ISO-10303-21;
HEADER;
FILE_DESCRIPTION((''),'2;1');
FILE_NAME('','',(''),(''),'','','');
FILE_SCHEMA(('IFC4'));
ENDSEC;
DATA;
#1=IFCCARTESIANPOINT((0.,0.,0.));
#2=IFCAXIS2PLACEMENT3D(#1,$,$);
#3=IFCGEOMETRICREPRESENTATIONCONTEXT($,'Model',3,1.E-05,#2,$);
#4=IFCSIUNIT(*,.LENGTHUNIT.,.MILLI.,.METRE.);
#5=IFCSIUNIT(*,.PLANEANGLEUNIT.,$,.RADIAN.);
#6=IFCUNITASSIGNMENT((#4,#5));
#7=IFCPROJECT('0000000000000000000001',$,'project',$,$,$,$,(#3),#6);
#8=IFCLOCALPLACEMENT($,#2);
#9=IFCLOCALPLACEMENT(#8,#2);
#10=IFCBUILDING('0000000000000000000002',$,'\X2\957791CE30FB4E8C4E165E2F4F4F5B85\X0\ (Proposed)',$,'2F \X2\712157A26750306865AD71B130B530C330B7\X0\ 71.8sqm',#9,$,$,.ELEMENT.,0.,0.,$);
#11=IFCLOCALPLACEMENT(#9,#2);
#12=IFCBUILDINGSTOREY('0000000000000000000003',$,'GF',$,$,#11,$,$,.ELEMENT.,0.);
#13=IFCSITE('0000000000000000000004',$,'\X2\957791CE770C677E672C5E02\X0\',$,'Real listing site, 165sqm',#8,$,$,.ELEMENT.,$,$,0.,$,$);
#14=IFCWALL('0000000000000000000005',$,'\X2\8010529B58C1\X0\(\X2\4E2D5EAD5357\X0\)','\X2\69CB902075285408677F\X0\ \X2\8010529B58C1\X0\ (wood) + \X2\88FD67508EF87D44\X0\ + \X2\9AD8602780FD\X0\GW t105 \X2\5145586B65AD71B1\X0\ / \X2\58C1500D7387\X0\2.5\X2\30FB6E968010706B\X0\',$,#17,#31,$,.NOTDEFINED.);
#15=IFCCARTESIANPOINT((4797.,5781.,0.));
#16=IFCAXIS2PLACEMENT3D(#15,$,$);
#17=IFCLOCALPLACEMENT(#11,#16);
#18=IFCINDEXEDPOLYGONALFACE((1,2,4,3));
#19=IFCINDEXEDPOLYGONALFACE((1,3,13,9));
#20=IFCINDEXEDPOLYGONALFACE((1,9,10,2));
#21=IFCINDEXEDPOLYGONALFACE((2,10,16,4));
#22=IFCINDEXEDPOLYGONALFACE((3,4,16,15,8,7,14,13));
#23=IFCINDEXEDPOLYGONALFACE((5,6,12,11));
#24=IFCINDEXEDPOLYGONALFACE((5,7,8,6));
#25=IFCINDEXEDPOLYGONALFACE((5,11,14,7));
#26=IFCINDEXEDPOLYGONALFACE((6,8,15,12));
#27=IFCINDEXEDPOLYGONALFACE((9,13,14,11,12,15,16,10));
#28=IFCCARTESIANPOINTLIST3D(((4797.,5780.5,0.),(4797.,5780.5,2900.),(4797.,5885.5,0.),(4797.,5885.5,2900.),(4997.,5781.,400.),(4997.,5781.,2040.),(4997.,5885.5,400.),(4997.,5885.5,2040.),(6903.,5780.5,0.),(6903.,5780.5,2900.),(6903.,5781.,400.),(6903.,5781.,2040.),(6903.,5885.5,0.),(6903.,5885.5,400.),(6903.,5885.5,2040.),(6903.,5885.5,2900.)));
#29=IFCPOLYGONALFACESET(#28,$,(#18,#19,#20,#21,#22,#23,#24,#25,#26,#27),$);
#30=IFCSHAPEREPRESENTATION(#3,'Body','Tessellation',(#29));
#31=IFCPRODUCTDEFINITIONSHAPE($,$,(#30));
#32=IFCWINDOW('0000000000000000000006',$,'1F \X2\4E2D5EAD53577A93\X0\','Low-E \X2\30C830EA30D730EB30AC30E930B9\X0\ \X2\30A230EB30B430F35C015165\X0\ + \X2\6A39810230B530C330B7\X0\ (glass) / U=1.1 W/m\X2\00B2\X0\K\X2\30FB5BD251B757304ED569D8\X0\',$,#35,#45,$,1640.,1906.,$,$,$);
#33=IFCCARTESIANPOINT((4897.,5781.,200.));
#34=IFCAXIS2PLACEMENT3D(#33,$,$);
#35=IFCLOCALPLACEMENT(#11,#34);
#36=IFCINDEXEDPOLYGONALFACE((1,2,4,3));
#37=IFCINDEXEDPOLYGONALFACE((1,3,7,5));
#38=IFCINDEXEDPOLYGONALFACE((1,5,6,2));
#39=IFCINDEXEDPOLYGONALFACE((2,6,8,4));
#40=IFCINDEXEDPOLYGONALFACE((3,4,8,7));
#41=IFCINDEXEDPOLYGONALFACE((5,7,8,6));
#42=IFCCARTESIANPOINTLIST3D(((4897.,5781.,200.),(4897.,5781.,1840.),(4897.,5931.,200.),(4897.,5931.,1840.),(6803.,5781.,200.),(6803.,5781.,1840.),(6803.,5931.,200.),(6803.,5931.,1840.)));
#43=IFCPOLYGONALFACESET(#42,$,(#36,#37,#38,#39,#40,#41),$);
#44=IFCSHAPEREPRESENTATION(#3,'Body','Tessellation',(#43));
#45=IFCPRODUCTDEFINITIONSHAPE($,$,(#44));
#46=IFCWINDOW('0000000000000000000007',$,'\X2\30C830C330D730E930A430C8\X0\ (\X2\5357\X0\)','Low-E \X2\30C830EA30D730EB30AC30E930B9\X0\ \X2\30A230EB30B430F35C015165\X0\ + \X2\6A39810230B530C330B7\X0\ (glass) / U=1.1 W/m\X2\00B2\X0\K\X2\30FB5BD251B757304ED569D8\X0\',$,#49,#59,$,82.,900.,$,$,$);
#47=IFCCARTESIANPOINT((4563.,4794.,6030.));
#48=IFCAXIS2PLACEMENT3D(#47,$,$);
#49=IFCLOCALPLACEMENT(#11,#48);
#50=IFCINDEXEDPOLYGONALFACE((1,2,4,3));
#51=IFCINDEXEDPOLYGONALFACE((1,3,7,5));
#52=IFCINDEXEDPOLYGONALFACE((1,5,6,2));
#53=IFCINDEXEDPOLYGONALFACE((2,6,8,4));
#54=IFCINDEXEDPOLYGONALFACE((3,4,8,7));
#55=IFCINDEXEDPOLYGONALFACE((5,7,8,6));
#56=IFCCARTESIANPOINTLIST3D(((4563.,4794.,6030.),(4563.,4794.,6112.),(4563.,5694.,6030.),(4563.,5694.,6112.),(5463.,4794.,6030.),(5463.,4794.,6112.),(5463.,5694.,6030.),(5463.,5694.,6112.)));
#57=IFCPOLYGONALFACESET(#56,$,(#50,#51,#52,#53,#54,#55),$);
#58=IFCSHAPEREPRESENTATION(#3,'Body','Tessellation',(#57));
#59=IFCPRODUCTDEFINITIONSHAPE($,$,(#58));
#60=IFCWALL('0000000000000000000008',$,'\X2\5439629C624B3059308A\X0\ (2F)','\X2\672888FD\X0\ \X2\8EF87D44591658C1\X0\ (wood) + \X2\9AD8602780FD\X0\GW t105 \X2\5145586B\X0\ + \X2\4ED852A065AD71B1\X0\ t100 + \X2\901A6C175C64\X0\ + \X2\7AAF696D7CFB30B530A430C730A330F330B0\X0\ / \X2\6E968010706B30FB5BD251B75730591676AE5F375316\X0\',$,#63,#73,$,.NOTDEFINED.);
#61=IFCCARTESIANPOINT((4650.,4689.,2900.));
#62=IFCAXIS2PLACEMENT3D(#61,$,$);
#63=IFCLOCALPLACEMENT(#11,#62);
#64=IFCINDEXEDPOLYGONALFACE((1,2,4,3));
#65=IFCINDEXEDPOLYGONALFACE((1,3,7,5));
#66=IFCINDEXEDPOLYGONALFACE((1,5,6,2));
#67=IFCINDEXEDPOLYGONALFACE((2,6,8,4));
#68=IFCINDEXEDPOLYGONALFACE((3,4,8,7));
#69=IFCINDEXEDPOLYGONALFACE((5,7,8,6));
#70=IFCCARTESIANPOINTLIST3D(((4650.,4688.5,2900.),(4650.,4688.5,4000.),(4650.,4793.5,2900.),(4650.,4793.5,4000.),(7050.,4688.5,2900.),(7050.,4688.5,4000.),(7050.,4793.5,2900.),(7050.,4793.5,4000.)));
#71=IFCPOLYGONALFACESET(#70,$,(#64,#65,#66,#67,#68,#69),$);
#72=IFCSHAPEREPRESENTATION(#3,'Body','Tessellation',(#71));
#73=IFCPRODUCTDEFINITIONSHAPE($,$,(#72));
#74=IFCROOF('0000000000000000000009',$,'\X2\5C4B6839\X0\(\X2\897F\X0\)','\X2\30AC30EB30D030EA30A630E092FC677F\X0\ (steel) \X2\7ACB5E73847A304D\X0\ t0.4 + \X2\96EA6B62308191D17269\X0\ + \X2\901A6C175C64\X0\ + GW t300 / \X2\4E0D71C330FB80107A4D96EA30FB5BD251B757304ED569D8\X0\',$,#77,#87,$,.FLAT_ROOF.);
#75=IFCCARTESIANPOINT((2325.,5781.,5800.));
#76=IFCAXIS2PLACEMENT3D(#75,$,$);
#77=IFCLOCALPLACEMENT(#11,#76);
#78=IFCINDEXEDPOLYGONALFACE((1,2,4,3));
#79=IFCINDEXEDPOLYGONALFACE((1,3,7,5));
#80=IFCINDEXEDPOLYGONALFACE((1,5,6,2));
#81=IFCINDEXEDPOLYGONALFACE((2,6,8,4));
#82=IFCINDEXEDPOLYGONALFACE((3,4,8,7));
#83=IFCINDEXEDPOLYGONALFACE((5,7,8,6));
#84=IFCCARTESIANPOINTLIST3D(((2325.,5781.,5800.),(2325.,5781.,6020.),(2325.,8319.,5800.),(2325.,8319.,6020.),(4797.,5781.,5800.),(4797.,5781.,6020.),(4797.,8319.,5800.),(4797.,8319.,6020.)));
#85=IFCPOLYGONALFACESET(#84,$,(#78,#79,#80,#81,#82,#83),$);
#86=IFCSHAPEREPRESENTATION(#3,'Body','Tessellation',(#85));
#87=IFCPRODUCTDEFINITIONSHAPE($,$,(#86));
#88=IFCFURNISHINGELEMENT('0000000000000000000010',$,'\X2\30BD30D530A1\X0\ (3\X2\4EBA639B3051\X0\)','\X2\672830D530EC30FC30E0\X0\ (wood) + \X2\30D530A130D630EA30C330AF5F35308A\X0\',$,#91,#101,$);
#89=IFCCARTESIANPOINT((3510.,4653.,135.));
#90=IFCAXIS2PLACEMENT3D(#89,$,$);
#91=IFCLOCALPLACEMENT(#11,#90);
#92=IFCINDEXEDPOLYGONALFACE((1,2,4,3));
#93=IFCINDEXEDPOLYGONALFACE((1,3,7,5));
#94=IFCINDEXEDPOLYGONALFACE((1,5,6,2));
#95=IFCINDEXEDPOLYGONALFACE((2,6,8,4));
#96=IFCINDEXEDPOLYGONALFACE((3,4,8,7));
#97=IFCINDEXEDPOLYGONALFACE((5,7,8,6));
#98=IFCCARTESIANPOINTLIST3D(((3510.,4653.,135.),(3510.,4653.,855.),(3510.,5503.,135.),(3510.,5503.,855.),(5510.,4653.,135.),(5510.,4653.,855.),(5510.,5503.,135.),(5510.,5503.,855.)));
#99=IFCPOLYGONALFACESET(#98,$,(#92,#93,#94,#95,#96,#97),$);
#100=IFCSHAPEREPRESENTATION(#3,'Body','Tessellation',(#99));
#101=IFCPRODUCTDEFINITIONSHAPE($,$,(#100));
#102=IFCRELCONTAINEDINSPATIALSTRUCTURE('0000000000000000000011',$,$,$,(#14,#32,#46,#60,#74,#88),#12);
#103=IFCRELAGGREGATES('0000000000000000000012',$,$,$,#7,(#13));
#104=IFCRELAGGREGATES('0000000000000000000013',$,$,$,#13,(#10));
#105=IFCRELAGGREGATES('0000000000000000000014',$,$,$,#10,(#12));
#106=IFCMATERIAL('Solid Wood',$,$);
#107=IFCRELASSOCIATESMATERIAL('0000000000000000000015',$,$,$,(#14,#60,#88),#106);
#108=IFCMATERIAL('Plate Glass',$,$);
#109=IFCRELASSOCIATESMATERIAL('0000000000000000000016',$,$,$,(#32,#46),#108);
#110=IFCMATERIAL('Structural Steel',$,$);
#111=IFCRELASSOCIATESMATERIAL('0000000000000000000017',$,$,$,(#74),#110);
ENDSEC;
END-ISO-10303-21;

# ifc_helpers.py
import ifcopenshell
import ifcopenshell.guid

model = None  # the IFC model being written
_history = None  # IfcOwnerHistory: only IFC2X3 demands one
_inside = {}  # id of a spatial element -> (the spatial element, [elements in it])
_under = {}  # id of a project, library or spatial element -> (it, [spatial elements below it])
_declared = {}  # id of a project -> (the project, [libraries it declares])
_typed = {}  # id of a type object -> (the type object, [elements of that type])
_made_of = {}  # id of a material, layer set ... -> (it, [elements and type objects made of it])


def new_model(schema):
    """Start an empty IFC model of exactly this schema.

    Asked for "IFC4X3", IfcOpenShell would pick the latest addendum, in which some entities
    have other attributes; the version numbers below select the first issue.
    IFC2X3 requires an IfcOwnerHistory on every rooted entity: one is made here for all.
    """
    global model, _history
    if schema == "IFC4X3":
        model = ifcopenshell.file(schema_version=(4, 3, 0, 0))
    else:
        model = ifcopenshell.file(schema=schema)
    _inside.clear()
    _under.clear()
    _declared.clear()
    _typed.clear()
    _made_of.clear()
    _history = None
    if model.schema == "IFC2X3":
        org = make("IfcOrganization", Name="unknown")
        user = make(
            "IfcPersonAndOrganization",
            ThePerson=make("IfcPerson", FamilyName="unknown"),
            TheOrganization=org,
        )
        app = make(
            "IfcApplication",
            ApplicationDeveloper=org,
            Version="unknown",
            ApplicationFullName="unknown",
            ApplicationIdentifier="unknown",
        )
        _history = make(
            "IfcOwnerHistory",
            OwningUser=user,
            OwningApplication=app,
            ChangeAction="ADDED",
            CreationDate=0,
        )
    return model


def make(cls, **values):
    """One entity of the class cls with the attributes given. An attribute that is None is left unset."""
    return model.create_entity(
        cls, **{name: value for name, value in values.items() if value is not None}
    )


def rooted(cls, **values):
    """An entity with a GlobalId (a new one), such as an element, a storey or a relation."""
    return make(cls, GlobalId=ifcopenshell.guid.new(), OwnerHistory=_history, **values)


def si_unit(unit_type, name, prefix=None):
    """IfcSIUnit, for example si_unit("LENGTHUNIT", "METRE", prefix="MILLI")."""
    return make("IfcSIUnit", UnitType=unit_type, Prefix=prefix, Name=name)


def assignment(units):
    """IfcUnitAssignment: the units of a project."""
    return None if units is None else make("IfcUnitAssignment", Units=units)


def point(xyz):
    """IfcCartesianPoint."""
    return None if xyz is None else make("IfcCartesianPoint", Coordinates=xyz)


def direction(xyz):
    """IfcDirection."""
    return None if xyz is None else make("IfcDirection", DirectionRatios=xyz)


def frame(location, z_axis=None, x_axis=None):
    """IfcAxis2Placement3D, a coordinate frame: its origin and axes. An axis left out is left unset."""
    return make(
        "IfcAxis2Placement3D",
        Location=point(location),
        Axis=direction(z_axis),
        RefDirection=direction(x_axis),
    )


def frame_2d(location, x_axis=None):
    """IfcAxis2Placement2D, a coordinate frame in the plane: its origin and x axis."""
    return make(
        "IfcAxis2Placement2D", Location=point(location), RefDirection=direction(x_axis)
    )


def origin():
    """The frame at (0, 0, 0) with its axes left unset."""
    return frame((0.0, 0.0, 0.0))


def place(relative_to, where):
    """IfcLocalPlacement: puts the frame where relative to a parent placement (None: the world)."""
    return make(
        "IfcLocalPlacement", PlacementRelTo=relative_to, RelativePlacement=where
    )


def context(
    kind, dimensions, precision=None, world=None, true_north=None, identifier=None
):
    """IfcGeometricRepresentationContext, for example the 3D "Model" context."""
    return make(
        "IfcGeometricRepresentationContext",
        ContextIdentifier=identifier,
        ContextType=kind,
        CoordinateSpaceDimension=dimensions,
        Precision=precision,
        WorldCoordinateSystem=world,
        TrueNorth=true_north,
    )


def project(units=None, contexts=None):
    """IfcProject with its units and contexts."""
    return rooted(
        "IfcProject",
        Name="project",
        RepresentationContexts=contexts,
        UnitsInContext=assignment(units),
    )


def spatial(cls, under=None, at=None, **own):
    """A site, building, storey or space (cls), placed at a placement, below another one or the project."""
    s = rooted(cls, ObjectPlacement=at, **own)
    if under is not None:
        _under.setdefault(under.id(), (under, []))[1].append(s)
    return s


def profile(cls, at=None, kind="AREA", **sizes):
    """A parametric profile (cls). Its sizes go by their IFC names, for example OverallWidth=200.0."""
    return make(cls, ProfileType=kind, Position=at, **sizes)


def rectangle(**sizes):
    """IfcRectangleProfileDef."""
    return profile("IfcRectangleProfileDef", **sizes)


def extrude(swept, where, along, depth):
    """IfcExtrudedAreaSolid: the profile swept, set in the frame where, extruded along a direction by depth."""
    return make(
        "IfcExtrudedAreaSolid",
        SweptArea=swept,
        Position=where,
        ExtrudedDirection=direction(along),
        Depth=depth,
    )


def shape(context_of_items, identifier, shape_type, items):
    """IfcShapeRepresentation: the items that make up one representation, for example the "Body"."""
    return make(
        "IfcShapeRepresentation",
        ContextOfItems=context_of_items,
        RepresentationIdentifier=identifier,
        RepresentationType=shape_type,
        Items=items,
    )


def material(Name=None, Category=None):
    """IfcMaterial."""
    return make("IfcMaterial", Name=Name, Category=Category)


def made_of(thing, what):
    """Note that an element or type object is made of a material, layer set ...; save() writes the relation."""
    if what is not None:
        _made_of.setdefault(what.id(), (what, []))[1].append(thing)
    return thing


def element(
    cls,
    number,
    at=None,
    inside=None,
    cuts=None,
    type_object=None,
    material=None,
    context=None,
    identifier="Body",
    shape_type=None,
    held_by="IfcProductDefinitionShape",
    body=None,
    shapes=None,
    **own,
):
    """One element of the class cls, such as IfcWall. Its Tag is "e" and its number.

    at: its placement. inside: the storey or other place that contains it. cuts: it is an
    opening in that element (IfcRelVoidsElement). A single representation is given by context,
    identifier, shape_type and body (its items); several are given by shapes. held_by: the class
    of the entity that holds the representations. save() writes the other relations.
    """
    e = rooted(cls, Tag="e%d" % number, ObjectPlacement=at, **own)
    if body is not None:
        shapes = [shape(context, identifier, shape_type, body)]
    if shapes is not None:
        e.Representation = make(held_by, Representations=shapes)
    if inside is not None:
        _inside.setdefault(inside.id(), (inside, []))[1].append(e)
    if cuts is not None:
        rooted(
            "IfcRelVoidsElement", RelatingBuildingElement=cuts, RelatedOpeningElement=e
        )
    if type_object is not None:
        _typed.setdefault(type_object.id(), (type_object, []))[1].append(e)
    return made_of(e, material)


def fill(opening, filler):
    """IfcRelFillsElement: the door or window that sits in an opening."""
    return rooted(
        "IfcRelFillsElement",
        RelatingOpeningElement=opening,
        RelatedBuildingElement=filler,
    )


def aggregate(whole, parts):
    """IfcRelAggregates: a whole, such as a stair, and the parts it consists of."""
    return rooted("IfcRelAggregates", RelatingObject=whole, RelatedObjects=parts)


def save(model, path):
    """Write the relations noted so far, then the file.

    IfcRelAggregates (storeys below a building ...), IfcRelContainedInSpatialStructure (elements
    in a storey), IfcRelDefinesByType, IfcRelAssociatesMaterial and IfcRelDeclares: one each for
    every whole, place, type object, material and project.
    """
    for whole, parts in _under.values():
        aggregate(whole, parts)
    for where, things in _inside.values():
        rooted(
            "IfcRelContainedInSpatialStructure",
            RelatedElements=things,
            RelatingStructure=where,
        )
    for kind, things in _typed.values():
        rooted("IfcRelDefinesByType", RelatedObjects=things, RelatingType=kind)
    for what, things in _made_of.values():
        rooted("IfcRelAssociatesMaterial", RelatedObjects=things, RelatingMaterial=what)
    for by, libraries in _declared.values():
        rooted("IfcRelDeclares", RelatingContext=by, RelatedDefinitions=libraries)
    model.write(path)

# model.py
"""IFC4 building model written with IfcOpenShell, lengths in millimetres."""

from ifc_helpers import new_model, si_unit, frame, frame_2d, origin, place, context, project, spatial, rectangle, extrude, material, element, fill, save


model = new_model("IFC4")

# Units and contexts
model_context = context("Model", 3, precision=1e-05, world=origin())
ifc_project = project(units=[si_unit("LENGTHUNIT", "METRE", prefix="MILLI"), si_unit("PLANEANGLEUNIT", "RADIAN")], contexts=[model_context])

# Site, building, storey
site_placement = place(None, origin())
site = spatial("IfcSite", under=ifc_project, at=site_placement, Name="長野県松本市", ObjectType="Real listing site, 165sqm", CompositionType="ELEMENT", RefElevation=0.0)
building_placement = place(site_placement, origin())
building = spatial("IfcBuilding", under=site, at=building_placement, Name="長野・二世帯住宅 (Proposed)", ObjectType="2F 無垢材と断熱サッシ 71.8sqm", CompositionType="ELEMENT", ElevationOfRefHeight=0.0, ElevationOfTerrain=0.0)
storey_placement = place(building_placement, origin())
storey = spatial("IfcBuildingStorey", under=building, at=storey_placement, Name="GF", CompositionType="ELEMENT", Elevation=0.0)

# Shared definitions
ifc_material_1 = material(Name="Solid Wood")

# Wall, opening, window
wall_1_placement = place(storey_placement, frame((4797.0, 5781.0, 0.0)))
wall_1 = element("IfcWall", 1, at=wall_1_placement, inside=storey, material=ifc_material_1, Name="耐力壁(中庭南)", Description="構造用合板 耐力壁 (wood) + 製材軸組 + 高性能GW t105 充填断熱 / 壁倍率2.5・準耐火", PredefinedType="NOTDEFINED", context=model_context, shape_type="SweptSolid", body=[
    extrude(rectangle(XDim=2106.0, YDim=105.0, at=frame_2d((1053.0, 52.0))), frame((4797.0, 5781.0, 0.0)), (0.0, 0.0, 1.0), 2900.0),
])
opening_placement = place(storey_placement, frame((4897.0, 5781.0, 200.0)))
opening = element("IfcOpeningElement", 2, at=opening_placement, cuts=wall_1, PredefinedType="NOTDEFINED", context=model_context, shape_type="SweptSolid", body=[
    extrude(rectangle(XDim=1906.0, YDim=150.0, at=frame_2d((953.0, 75.0))), frame((4897.0, 5781.0, 200.0)), (0.0, 0.0, 1.0), 1640.0),
])
ifc_material_2 = material(Name="Plate Glass")
window_1_placement = place(storey_placement, frame((4897.0, 5781.0, 200.0)))
window_1 = element("IfcWindow", 3, at=window_1_placement, inside=storey, material=ifc_material_2, Name="1F 中庭南窓", Description="Low-E トリプルガラス アルゴン封入 + 樹脂サッシ (glass) / U=1.1 W/m²K・寒冷地仕様", OverallHeight=1640.0, OverallWidth=1906.0, context=model_context, shape_type="SweptSolid", body=[
    extrude(rectangle(XDim=1906.0, YDim=150.0, at=frame_2d((953.0, 75.0))), frame((4897.0, 5781.0, 200.0)), (0.0, 0.0, 1.0), 1640.0),
])
fill(opening, window_1)

# Window
window_2_placement = place(storey_placement, frame((4563.0, 4794.0, 6030.0)))
element("IfcWindow", 4, at=window_2_placement, inside=storey, material=ifc_material_2, Name="トップライト (南)", Description="Low-E トリプルガラス アルゴン封入 + 樹脂サッシ (glass) / U=1.1 W/m²K・寒冷地仕様", OverallHeight=82.0, OverallWidth=900.0, context=model_context, shape_type="SweptSolid", body=[
    extrude(rectangle(XDim=900.0, YDim=900.0, at=frame_2d((450.0, 450.0))), frame((4563.0, 4794.0, 6030.0)), (0.0, 0.0, 1.0), 82.0),
])

# Wall
wall_2_placement = place(storey_placement, frame((4650.0, 4689.0, 2900.0)))
element("IfcWall", 5, at=wall_2_placement, inside=storey, material=ifc_material_1, Name="吹抜手すり (2F)", Description="木製 軸組外壁 (wood) + 高性能GW t105 充填 + 付加断熱 t100 + 通気層 + 窯業系サイディング / 準耐火・寒冷地外皮強化", PredefinedType="NOTDEFINED", context=model_context, shape_type="SweptSolid", body=[
    extrude(rectangle(XDim=2400.0, YDim=105.0, at=frame_2d((1200.0, 52.0))), frame((4650.0, 4689.0, 2900.0)), (0.0, 0.0, 1.0), 1100.0),
])

# Roof
ifc_material_3 = material(Name="Structural Steel")
for number, where, name in (
    (6, (2325.0, 5781.0, 5800.0), "屋根(西)"),
):
    element("IfcRoof", number, at=place(storey_placement, frame(where)), inside=storey, material=ifc_material_3, Name=name, Description="ガルバリウム鋼板 (steel) 立平葺き t0.4 + 雪止め金物 + 通気層 + GW t300 / 不燃・耐積雪・寒冷地仕様", PredefinedType="FLAT_ROOF", context=model_context, shape_type="SweptSolid", body=[
        extrude(rectangle(XDim=2472.0, YDim=2538.0, at=frame_2d((1236.0, 1269.0))), frame((2325.0, 5781.0, 5800.0)), (0.0, 0.0, 1.0), 220.0),
    ])

# Furnishing element
furnishing_placement = place(storey_placement, frame((3510.0, 4653.0, 135.0)))
element("IfcFurnishingElement", 7, at=furnishing_placement, inside=storey, material=ifc_material_1, Name="ソファ (3人掛け)", Description="木フレーム (wood) + ファブリック張り", context=model_context, shape_type="SweptSolid", body=[
    extrude(rectangle(XDim=2000.0, YDim=850.0, at=frame_2d((1000.0, 425.0))), frame((3510.0, 4653.0, 135.0)), (0.0, 0.0, 1.0), 720.0),
])

save(model, "model.ifc")
